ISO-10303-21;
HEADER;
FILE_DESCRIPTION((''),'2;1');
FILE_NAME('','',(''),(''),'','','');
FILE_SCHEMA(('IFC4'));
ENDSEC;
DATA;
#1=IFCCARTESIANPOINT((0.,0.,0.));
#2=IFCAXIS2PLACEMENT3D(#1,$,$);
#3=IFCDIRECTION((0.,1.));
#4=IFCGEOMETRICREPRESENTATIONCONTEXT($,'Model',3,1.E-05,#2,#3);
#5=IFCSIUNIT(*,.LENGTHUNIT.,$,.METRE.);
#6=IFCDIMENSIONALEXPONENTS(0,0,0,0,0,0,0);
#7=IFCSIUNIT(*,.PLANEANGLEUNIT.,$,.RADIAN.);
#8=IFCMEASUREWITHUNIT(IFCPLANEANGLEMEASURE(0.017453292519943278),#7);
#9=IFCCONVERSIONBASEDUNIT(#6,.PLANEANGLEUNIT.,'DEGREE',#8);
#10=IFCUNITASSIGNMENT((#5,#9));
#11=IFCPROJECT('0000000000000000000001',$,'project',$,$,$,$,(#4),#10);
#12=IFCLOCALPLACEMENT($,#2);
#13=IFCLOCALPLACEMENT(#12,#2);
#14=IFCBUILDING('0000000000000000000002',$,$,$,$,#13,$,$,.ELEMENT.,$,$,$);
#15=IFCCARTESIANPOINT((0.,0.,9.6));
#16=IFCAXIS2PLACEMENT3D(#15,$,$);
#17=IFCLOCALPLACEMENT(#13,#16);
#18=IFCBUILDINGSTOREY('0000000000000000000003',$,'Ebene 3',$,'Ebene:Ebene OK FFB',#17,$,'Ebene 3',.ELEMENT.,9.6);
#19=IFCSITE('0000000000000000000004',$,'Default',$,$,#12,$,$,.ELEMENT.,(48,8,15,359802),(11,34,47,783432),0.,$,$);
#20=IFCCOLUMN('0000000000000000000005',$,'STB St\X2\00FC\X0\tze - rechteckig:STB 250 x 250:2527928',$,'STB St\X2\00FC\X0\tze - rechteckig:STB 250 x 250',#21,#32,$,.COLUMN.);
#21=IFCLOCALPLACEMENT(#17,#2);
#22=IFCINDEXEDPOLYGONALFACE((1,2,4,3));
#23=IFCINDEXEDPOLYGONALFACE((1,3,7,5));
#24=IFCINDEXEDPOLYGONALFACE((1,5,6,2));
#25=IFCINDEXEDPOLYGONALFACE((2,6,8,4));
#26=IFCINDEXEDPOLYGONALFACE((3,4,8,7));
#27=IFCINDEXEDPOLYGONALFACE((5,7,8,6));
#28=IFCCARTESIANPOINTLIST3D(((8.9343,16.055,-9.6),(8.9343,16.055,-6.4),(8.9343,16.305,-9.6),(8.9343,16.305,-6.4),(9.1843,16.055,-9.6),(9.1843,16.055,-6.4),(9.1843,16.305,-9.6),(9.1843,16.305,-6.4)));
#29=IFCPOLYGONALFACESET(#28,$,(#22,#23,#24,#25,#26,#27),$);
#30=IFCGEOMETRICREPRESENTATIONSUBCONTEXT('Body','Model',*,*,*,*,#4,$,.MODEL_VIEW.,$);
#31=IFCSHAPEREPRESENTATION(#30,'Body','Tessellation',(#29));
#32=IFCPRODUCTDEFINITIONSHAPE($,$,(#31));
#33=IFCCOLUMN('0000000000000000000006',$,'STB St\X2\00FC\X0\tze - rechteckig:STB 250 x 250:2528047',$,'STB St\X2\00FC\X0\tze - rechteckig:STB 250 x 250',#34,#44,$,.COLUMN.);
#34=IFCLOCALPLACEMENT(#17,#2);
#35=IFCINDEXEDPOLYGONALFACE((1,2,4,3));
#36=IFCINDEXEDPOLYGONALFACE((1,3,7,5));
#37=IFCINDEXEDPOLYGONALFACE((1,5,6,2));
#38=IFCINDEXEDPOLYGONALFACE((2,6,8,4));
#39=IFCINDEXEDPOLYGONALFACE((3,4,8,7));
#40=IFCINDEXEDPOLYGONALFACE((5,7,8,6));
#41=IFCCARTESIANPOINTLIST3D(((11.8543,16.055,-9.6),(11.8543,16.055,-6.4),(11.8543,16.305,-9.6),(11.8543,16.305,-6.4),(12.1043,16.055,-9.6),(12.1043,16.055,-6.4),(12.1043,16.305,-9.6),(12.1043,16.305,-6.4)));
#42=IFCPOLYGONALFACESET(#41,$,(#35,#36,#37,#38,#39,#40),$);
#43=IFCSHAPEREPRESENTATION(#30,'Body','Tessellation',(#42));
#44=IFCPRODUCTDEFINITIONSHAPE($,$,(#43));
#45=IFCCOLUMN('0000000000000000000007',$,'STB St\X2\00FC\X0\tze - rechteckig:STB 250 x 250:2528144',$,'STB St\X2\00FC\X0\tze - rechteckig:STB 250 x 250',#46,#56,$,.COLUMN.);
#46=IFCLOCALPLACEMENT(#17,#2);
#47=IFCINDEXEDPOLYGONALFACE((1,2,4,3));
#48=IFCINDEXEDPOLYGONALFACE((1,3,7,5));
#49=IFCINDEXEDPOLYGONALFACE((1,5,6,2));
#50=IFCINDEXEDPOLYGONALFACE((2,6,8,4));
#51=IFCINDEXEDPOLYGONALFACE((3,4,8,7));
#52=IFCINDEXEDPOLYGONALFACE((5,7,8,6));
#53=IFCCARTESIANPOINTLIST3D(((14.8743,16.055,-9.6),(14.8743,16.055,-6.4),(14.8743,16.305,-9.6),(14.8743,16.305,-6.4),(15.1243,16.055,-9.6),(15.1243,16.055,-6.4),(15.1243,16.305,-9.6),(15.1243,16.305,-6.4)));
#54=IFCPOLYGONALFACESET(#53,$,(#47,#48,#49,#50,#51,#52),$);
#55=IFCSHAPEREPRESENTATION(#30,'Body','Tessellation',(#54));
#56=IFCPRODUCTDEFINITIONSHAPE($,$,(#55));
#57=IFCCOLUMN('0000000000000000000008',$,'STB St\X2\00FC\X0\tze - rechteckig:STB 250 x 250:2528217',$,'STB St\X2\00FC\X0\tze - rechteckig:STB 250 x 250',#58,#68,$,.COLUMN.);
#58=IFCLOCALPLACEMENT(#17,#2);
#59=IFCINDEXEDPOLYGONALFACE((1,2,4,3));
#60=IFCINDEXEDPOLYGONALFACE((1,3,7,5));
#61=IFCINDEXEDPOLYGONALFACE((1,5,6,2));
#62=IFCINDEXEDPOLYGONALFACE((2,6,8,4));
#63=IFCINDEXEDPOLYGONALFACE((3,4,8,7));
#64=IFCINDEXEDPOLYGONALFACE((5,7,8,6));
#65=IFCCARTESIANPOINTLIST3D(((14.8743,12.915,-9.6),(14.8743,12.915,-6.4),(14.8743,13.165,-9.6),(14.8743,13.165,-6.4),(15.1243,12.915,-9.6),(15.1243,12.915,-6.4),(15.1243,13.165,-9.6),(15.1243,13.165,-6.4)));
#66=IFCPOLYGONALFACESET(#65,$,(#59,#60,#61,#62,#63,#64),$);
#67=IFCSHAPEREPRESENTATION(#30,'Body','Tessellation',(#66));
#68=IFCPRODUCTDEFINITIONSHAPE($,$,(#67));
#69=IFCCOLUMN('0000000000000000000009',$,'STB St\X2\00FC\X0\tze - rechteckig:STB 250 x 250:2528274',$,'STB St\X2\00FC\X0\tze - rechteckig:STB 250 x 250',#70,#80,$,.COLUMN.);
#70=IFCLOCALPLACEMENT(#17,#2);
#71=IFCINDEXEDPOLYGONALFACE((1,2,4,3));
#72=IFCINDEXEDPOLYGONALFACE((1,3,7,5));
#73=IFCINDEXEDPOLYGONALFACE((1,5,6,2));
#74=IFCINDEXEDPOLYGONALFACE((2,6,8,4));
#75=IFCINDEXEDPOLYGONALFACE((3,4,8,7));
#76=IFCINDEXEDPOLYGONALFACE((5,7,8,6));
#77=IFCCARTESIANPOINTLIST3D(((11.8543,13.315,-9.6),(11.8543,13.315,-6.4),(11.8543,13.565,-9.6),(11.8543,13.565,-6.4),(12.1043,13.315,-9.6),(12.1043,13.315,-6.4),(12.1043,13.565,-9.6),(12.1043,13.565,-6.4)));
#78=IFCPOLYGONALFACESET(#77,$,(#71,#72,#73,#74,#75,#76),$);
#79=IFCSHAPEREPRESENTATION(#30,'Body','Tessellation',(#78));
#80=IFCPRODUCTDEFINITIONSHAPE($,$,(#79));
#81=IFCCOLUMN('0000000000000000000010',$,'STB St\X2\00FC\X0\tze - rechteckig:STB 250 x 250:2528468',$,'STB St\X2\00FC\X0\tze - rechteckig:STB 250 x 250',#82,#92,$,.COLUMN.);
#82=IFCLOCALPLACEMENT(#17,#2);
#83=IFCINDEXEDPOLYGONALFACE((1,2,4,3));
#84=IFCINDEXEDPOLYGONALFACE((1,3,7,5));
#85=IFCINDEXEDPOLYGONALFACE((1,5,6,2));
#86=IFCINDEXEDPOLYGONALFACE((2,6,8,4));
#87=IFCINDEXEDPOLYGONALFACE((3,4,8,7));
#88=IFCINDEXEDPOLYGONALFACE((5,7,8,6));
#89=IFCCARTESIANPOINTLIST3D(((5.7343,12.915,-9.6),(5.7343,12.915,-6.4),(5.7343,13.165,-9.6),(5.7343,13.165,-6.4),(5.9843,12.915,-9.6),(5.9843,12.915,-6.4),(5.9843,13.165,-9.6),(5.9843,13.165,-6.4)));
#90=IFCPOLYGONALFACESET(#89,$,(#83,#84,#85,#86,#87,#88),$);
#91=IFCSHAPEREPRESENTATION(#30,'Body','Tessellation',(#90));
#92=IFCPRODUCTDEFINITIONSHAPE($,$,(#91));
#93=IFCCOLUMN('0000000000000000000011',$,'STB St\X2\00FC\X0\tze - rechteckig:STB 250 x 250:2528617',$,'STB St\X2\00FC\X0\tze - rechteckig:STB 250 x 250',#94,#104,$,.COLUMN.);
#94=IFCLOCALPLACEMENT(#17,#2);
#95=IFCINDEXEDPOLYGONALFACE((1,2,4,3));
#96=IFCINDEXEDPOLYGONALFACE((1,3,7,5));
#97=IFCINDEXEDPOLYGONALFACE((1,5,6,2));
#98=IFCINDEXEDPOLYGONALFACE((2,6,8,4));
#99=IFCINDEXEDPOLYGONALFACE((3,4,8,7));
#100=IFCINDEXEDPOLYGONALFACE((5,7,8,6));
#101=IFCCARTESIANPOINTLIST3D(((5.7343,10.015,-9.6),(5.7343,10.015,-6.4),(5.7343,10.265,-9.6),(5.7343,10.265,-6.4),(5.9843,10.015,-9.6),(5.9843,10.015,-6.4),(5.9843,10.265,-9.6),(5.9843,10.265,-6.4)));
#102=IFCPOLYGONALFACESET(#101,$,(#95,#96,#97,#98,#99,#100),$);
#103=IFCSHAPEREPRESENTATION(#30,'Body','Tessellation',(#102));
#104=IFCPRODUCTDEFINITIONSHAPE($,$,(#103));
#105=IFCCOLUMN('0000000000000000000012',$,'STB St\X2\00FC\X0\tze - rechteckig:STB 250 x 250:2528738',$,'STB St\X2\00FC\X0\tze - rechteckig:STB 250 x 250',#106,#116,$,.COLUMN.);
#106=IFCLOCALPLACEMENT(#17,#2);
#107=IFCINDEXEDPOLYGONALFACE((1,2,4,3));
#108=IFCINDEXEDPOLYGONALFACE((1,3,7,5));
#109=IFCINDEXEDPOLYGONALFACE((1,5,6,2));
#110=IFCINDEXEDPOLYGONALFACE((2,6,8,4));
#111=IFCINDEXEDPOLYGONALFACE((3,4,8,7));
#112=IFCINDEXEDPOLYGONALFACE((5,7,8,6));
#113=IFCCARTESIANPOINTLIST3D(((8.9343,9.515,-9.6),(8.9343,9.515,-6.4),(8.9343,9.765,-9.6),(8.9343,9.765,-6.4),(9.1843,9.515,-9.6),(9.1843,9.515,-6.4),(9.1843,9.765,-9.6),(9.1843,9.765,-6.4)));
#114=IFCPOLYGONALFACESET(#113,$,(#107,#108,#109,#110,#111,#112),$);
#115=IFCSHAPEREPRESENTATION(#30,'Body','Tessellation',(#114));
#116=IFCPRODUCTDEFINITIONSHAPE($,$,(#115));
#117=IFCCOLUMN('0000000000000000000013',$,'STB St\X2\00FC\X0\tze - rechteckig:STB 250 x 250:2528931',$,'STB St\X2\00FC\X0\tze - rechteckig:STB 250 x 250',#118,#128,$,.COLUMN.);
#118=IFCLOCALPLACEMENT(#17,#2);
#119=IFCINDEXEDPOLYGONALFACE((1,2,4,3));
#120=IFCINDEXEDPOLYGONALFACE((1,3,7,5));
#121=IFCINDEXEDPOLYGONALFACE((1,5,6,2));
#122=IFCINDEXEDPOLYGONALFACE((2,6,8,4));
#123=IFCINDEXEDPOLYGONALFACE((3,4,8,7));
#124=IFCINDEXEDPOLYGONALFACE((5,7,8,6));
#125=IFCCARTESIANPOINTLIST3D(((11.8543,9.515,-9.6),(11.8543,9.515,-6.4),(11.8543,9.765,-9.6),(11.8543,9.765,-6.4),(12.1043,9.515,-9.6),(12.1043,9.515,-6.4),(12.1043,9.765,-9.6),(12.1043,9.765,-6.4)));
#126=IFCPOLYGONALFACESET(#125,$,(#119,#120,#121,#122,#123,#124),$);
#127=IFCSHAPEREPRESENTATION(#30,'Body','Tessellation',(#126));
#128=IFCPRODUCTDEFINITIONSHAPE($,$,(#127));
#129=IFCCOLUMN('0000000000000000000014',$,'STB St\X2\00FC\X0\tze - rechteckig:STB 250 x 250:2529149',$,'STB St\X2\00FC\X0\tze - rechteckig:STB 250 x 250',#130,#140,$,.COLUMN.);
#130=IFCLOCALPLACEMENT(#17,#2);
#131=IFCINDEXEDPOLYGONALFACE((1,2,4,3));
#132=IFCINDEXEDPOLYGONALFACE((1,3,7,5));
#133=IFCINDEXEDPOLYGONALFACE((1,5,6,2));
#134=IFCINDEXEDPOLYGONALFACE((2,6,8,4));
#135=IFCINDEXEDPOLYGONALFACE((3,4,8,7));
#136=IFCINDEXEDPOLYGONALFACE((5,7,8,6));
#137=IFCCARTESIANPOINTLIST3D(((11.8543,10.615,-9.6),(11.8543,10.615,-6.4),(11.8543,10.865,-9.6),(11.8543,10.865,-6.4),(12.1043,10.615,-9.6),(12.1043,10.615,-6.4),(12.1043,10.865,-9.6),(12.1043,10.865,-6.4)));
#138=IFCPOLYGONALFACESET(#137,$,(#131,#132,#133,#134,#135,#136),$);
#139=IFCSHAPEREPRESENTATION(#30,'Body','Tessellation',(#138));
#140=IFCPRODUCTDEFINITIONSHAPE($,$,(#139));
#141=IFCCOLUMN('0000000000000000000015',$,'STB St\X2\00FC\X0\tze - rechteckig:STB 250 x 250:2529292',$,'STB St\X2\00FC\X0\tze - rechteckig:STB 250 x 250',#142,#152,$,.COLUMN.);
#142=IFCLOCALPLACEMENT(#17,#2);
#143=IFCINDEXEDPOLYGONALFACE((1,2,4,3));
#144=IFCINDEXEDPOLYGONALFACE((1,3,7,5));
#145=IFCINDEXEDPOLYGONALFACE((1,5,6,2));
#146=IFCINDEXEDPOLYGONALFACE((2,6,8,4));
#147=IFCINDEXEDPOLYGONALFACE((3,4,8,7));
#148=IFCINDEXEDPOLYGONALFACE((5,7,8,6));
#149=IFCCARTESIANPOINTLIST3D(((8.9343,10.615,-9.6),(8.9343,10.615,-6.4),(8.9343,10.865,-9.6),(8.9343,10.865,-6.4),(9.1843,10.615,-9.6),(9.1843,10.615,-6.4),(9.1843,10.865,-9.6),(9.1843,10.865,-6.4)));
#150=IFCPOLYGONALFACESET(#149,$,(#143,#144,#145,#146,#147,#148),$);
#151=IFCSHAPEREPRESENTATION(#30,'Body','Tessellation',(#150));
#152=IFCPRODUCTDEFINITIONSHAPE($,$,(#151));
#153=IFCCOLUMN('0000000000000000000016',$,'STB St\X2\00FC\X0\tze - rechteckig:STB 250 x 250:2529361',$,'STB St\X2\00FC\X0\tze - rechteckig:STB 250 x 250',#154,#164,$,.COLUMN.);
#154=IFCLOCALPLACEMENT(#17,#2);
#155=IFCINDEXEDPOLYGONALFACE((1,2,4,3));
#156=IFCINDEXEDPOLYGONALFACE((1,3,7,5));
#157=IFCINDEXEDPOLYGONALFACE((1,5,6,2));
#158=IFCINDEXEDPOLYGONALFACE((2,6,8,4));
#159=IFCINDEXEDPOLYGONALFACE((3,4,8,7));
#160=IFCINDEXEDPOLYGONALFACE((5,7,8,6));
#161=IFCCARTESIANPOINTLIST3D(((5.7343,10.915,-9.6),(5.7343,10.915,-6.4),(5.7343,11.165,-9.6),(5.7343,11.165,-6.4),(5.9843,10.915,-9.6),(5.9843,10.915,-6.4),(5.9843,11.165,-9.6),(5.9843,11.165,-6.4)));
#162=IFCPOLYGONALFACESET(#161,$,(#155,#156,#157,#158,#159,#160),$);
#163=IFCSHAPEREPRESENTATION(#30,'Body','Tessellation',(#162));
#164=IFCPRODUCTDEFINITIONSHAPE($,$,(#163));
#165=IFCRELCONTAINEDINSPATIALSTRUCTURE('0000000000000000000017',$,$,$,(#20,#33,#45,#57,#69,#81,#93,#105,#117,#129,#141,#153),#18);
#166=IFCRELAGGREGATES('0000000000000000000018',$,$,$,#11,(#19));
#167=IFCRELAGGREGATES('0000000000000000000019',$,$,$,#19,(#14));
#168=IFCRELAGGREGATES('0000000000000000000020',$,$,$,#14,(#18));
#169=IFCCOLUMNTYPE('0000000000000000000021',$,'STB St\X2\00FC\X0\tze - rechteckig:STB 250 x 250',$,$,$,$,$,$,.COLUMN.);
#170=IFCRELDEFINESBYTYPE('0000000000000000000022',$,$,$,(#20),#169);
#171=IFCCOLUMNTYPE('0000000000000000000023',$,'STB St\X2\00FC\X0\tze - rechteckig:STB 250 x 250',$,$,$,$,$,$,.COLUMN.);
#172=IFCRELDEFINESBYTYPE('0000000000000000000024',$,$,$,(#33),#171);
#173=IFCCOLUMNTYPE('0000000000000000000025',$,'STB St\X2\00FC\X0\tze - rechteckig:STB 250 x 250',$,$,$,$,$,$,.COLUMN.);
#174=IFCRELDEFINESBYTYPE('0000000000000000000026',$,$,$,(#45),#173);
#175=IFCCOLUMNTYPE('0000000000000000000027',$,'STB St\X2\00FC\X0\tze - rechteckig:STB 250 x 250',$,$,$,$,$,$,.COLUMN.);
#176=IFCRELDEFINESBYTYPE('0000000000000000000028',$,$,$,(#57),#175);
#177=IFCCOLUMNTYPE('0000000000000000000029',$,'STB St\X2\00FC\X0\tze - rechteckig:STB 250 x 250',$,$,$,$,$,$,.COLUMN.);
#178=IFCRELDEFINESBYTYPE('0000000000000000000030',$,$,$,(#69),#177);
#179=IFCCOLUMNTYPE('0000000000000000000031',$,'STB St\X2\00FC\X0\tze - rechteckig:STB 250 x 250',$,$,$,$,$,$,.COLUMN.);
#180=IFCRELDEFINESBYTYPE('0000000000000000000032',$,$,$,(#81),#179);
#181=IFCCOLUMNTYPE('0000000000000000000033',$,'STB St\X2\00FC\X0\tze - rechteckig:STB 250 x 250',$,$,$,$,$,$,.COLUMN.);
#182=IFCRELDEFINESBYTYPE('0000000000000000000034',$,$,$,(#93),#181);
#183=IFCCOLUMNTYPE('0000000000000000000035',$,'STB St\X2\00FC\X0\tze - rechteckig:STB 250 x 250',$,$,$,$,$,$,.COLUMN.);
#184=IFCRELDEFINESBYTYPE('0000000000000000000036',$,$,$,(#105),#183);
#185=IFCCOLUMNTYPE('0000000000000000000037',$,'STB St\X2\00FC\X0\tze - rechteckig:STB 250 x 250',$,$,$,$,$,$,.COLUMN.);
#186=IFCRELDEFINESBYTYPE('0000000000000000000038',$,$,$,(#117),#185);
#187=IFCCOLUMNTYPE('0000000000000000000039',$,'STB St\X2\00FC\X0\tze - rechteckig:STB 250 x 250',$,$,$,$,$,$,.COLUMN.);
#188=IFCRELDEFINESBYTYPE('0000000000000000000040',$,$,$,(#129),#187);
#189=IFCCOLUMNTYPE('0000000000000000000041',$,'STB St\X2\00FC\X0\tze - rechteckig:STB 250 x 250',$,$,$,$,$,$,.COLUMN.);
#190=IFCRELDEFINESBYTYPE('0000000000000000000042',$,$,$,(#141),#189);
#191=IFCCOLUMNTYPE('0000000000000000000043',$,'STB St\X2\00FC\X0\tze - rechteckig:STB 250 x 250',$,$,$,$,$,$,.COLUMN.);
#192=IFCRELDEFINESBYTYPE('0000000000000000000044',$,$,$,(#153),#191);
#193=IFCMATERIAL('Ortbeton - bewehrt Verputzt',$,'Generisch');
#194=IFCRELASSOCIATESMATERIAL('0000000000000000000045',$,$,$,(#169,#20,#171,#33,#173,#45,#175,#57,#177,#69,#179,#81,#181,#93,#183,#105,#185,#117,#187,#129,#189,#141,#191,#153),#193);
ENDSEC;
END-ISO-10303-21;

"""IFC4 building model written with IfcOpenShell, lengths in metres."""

from ifc_helpers import new_model, entity, si_unit, converted_unit, direction, frame, origin, place, context, subcontext, project, spatial, indexed_curve, outline, extrude, source, transform, mapped, material, type_object, type_shapes, element, save


model = new_model("IFC4")

# Units and contexts
model_context = context("Model", 3, precision=1e-05, world=origin(), true_north=direction((0.0, 1.0)))
body_context = subcontext(model_context, "Body", "Model", "MODEL_VIEW")
ifc_project = project(units=[si_unit("LENGTHUNIT", "METRE"), converted_unit("PLANEANGLEUNIT", "DEGREE", entity("IfcPlaneAngleMeasure", 0.017453292519943278), si_unit("PLANEANGLEUNIT", "RADIAN"), dimensions=[0, 0, 0, 0, 0, 0, 0])], contexts=[model_context])

# Site, building, storey
site_placement = place(None, origin())
site = spatial("IfcSite", under=ifc_project, at=site_placement, Name="Default", CompositionType="ELEMENT", RefLatitude=(48, 8, 15, 359802), RefLongitude=(11, 34, 47, 783432), RefElevation=0.0)
building_placement = place(site_placement, origin())
building = spatial("IfcBuilding", under=site, at=building_placement, CompositionType="ELEMENT")
storey_placement = place(building_placement, frame((0.0, 0.0, 9.6)))
storey = spatial("IfcBuildingStorey", under=building, at=storey_placement, Name="Ebene 3", ObjectType="Ebene:Ebene OK FFB", LongName="Ebene 3", CompositionType="ELEMENT", Elevation=9.6)

# Columns
ifc_material_1 = material(Name="Ortbeton - bewehrt Verputzt", Category="Generisch")
column_type_1 = type_object("IfcColumnType", Name="STB Stütze - rechteckig:STB 250 x 250", PredefinedType="COLUMN", material=ifc_material_1)
shared_shape_1 = source(origin(), body_context, "Body", "SweptSolid", [
    extrude(outline(indexed_curve([(-0.125, -0.125), (0.125, -0.125), (0.125, 0.125), (-0.125, 0.125), (-0.125, -0.125)], self_intersect=False)), frame((9.0593, 16.18, 0.0), z_axis=(0.0, 0.0, 1.0), x_axis=(-1.0, 0.0, 0.0)), (0.0, 0.0, 1.0), 3.2),
])
type_shapes(column_type_1, [shared_shape_1])
column_1_placement = place(storey_placement, frame((0.0, 0.0, -9.6)))
element("IfcColumn", 1, at=column_1_placement, inside=storey, type_object=column_type_1, material=ifc_material_1, Name="STB Stütze - rechteckig:STB 250 x 250:2527928", ObjectType="STB Stütze - rechteckig:STB 250 x 250", PredefinedType="COLUMN", context=body_context, shape_type="MappedRepresentation", body=[
    mapped(shared_shape_1, transform((0.0, 0.0, 0.0), scale=1.0)),
])
column_type_2 = type_object("IfcColumnType", Name="STB Stütze - rechteckig:STB 250 x 250", PredefinedType="COLUMN", material=ifc_material_1)
shared_shape_2 = source(origin(), body_context, "Body", "SweptSolid", [
    extrude(outline(indexed_curve([(-0.125, -0.125), (0.125, -0.125), (0.125, 0.125), (-0.125, 0.125), (-0.125, -0.125)], self_intersect=False)), frame((11.9793, 16.18, 0.0), z_axis=(0.0, 0.0, 1.0), x_axis=(-1.0, 0.0, 0.0)), (0.0, 0.0, 1.0), 3.2),
])
type_shapes(column_type_2, [shared_shape_2])
column_2_placement = place(storey_placement, frame((0.0, 0.0, -9.6)))
element("IfcColumn", 2, at=column_2_placement, inside=storey, type_object=column_type_2, material=ifc_material_1, Name="STB Stütze - rechteckig:STB 250 x 250:2528047", ObjectType="STB Stütze - rechteckig:STB 250 x 250", PredefinedType="COLUMN", context=body_context, shape_type="MappedRepresentation", body=[
    mapped(shared_shape_2, transform((0.0, 0.0, 0.0), scale=1.0)),
])
column_type_3 = type_object("IfcColumnType", Name="STB Stütze - rechteckig:STB 250 x 250", PredefinedType="COLUMN", material=ifc_material_1)
shared_shape_3 = source(origin(), body_context, "Body", "SweptSolid", [
    extrude(outline(indexed_curve([(-0.125, -0.125), (0.125, -0.125), (0.125, 0.125), (-0.125, 0.125), (-0.125, -0.125)], self_intersect=False)), frame((14.9993, 16.18, 0.0), z_axis=(0.0, 0.0, 1.0), x_axis=(-1.0, 0.0, 0.0)), (0.0, 0.0, 1.0), 3.2),
])
type_shapes(column_type_3, [shared_shape_3])
column_3_placement = place(storey_placement, frame((0.0, 0.0, -9.6)))
element("IfcColumn", 3, at=column_3_placement, inside=storey, type_object=column_type_3, material=ifc_material_1, Name="STB Stütze - rechteckig:STB 250 x 250:2528144", ObjectType="STB Stütze - rechteckig:STB 250 x 250", PredefinedType="COLUMN", context=body_context, shape_type="MappedRepresentation", body=[
    mapped(shared_shape_3, transform((0.0, 0.0, 0.0), scale=1.0)),
])
column_type_4 = type_object("IfcColumnType", Name="STB Stütze - rechteckig:STB 250 x 250", PredefinedType="COLUMN", material=ifc_material_1)
shared_shape_4 = source(origin(), body_context, "Body", "SweptSolid", [
    extrude(outline(indexed_curve([(-0.125, -0.125), (0.125, -0.125), (0.125, 0.125), (-0.125, 0.125), (-0.125, -0.125)], self_intersect=False)), frame((14.9993, 13.04, 0.0), z_axis=(0.0, 0.0, 1.0), x_axis=(-1.0, 0.0, 0.0)), (0.0, 0.0, 1.0), 3.2),
])
type_shapes(column_type_4, [shared_shape_4])
column_4_placement = place(storey_placement, frame((0.0, 0.0, -9.6)))
element("IfcColumn", 4, at=column_4_placement, inside=storey, type_object=column_type_4, material=ifc_material_1, Name="STB Stütze - rechteckig:STB 250 x 250:2528217", ObjectType="STB Stütze - rechteckig:STB 250 x 250", PredefinedType="COLUMN", context=body_context, shape_type="MappedRepresentation", body=[
    mapped(shared_shape_4, transform((0.0, 0.0, 0.0), scale=1.0)),
])
column_type_5 = type_object("IfcColumnType", Name="STB Stütze - rechteckig:STB 250 x 250", PredefinedType="COLUMN", material=ifc_material_1)
shared_shape_5 = source(origin(), body_context, "Body", "SweptSolid", [
    extrude(outline(indexed_curve([(-0.125, -0.125), (0.125, -0.125), (0.125, 0.125), (-0.125, 0.125), (-0.125, -0.125)], self_intersect=False)), frame((11.9793, 13.44, 0.0), z_axis=(0.0, 0.0, 1.0), x_axis=(-1.0, 0.0, 0.0)), (0.0, 0.0, 1.0), 3.2),
])
type_shapes(column_type_5, [shared_shape_5])
column_5_placement = place(storey_placement, frame((0.0, 0.0, -9.6)))
element("IfcColumn", 5, at=column_5_placement, inside=storey, type_object=column_type_5, material=ifc_material_1, Name="STB Stütze - rechteckig:STB 250 x 250:2528274", ObjectType="STB Stütze - rechteckig:STB 250 x 250", PredefinedType="COLUMN", context=body_context, shape_type="MappedRepresentation", body=[
    mapped(shared_shape_5, transform((0.0, 0.0, 0.0), scale=1.0)),
])
column_type_6 = type_object("IfcColumnType", Name="STB Stütze - rechteckig:STB 250 x 250", PredefinedType="COLUMN", material=ifc_material_1)
shared_shape_6 = source(origin(), body_context, "Body", "SweptSolid", [
    extrude(outline(indexed_curve([(-0.125, -0.125), (0.125, -0.125), (0.125, 0.125), (-0.125, 0.125), (-0.125, -0.125)], self_intersect=False)), frame((5.8593, 13.04, 0.0), z_axis=(0.0, 0.0, 1.0), x_axis=(-1.0, 0.0, 0.0)), (0.0, 0.0, 1.0), 3.2),
])
type_shapes(column_type_6, [shared_shape_6])
column_6_placement = place(storey_placement, frame((0.0, 0.0, -9.6)))
element("IfcColumn", 6, at=column_6_placement, inside=storey, type_object=column_type_6, material=ifc_material_1, Name="STB Stütze - rechteckig:STB 250 x 250:2528468", ObjectType="STB Stütze - rechteckig:STB 250 x 250", PredefinedType="COLUMN", context=body_context, shape_type="MappedRepresentation", body=[
    mapped(shared_shape_6, transform((0.0, 0.0, 0.0), scale=1.0)),
])
column_type_7 = type_object("IfcColumnType", Name="STB Stütze - rechteckig:STB 250 x 250", PredefinedType="COLUMN", material=ifc_material_1)
shared_shape_7 = source(origin(), body_context, "Body", "SweptSolid", [
    extrude(outline(indexed_curve([(-0.125, -0.125), (0.125, -0.125), (0.125, 0.125), (-0.125, 0.125), (-0.125, -0.125)], self_intersect=False)), frame((5.8593, 10.14, 0.0), z_axis=(0.0, 0.0, 1.0), x_axis=(-1.0, 0.0, 0.0)), (0.0, 0.0, 1.0), 3.2),
])
type_shapes(column_type_7, [shared_shape_7])
column_7_placement = place(storey_placement, frame((0.0, 0.0, -9.6)))
element("IfcColumn", 7, at=column_7_placement, inside=storey, type_object=column_type_7, material=ifc_material_1, Name="STB Stütze - rechteckig:STB 250 x 250:2528617", ObjectType="STB Stütze - rechteckig:STB 250 x 250", PredefinedType="COLUMN", context=body_context, shape_type="MappedRepresentation", body=[
    mapped(shared_shape_7, transform((0.0, 0.0, 0.0), scale=1.0)),
])
column_type_8 = type_object("IfcColumnType", Name="STB Stütze - rechteckig:STB 250 x 250", PredefinedType="COLUMN", material=ifc_material_1)
shared_shape_8 = source(origin(), body_context, "Body", "SweptSolid", [
    extrude(outline(indexed_curve([(-0.125, -0.125), (0.125, -0.125), (0.125, 0.125), (-0.125, 0.125), (-0.125, -0.125)], self_intersect=False)), frame((9.0593, 9.64, 0.0), z_axis=(0.0, 0.0, 1.0), x_axis=(-1.0, 0.0, 0.0)), (0.0, 0.0, 1.0), 3.2),
])
type_shapes(column_type_8, [shared_shape_8])
column_8_placement = place(storey_placement, frame((0.0, 0.0, -9.6)))
element("IfcColumn", 8, at=column_8_placement, inside=storey, type_object=column_type_8, material=ifc_material_1, Name="STB Stütze - rechteckig:STB 250 x 250:2528738", ObjectType="STB Stütze - rechteckig:STB 250 x 250", PredefinedType="COLUMN", context=body_context, shape_type="MappedRepresentation", body=[
    mapped(shared_shape_8, transform((0.0, 0.0, 0.0), scale=1.0)),
])
column_type_9 = type_object("IfcColumnType", Name="STB Stütze - rechteckig:STB 250 x 250", PredefinedType="COLUMN", material=ifc_material_1)
shared_shape_9 = source(origin(), body_context, "Body", "SweptSolid", [
    extrude(outline(indexed_curve([(-0.125, -0.125), (0.125, -0.125), (0.125, 0.125), (-0.125, 0.125), (-0.125, -0.125)], self_intersect=False)), frame((11.9793, 9.64, 0.0), z_axis=(0.0, 0.0, 1.0), x_axis=(-1.0, 0.0, 0.0)), (0.0, 0.0, 1.0), 3.2),
])
type_shapes(column_type_9, [shared_shape_9])
column_9_placement = place(storey_placement, frame((0.0, 0.0, -9.6)))
element("IfcColumn", 9, at=column_9_placement, inside=storey, type_object=column_type_9, material=ifc_material_1, Name="STB Stütze - rechteckig:STB 250 x 250:2528931", ObjectType="STB Stütze - rechteckig:STB 250 x 250", PredefinedType="COLUMN", context=body_context, shape_type="MappedRepresentation", body=[
    mapped(shared_shape_9, transform((0.0, 0.0, 0.0), scale=1.0)),
])
column_type_10 = type_object("IfcColumnType", Name="STB Stütze - rechteckig:STB 250 x 250", PredefinedType="COLUMN", material=ifc_material_1)
shared_shape_10 = source(origin(), body_context, "Body", "SweptSolid", [
    extrude(outline(indexed_curve([(-0.125, -0.125), (0.125, -0.125), (0.125, 0.125), (-0.125, 0.125), (-0.125, -0.125)], self_intersect=False)), frame((11.9793, 10.74, 0.0), z_axis=(0.0, 0.0, 1.0), x_axis=(-1.0, 0.0, 0.0)), (0.0, 0.0, 1.0), 3.2),
])
type_shapes(column_type_10, [shared_shape_10])
column_10_placement = place(storey_placement, frame((0.0, 0.0, -9.6)))
element("IfcColumn", 10, at=column_10_placement, inside=storey, type_object=column_type_10, material=ifc_material_1, Name="STB Stütze - rechteckig:STB 250 x 250:2529149", ObjectType="STB Stütze - rechteckig:STB 250 x 250", PredefinedType="COLUMN", context=body_context, shape_type="MappedRepresentation", body=[
    mapped(shared_shape_10, transform((0.0, 0.0, 0.0), scale=1.0)),
])
column_type_11 = type_object("IfcColumnType", Name="STB Stütze - rechteckig:STB 250 x 250", PredefinedType="COLUMN", material=ifc_material_1)
shared_shape_11 = source(origin(), body_context, "Body", "SweptSolid", [
    extrude(outline(indexed_curve([(-0.125, -0.125), (0.125, -0.125), (0.125, 0.125), (-0.125, 0.125), (-0.125, -0.125)], self_intersect=False)), frame((9.0593, 10.74, 0.0), z_axis=(0.0, 0.0, 1.0), x_axis=(-1.0, 0.0, 0.0)), (0.0, 0.0, 1.0), 3.2),
])
type_shapes(column_type_11, [shared_shape_11])
column_11_placement = place(storey_placement, frame((0.0, 0.0, -9.6)))
element("IfcColumn", 11, at=column_11_placement, inside=storey, type_object=column_type_11, material=ifc_material_1, Name="STB Stütze - rechteckig:STB 250 x 250:2529292", ObjectType="STB Stütze - rechteckig:STB 250 x 250", PredefinedType="COLUMN", context=body_context, shape_type="MappedRepresentation", body=[
    mapped(shared_shape_11, transform((0.0, 0.0, 0.0), scale=1.0)),
])
column_type_12 = type_object("IfcColumnType", Name="STB Stütze - rechteckig:STB 250 x 250", PredefinedType="COLUMN", material=ifc_material_1)
shared_shape_12 = source(origin(), body_context, "Body", "SweptSolid", [
    extrude(outline(indexed_curve([(-0.125, -0.125), (0.125, -0.125), (0.125, 0.125), (-0.125, 0.125), (-0.125, -0.125)], self_intersect=False)), frame((5.8593, 11.04, 0.0), z_axis=(0.0, 0.0, 1.0), x_axis=(-1.0, 0.0, 0.0)), (0.0, 0.0, 1.0), 3.2),
])
type_shapes(column_type_12, [shared_shape_12])
column_12_placement = place(storey_placement, frame((0.0, 0.0, -9.6)))
element("IfcColumn", 12, at=column_12_placement, inside=storey, type_object=column_type_12, material=ifc_material_1, Name="STB Stütze - rechteckig:STB 250 x 250:2529361", ObjectType="STB Stütze - rechteckig:STB 250 x 250", PredefinedType="COLUMN", context=body_context, shape_type="MappedRepresentation", body=[
    mapped(shared_shape_12, transform((0.0, 0.0, 0.0), scale=1.0)),
])

save(model, "model.ifc")
